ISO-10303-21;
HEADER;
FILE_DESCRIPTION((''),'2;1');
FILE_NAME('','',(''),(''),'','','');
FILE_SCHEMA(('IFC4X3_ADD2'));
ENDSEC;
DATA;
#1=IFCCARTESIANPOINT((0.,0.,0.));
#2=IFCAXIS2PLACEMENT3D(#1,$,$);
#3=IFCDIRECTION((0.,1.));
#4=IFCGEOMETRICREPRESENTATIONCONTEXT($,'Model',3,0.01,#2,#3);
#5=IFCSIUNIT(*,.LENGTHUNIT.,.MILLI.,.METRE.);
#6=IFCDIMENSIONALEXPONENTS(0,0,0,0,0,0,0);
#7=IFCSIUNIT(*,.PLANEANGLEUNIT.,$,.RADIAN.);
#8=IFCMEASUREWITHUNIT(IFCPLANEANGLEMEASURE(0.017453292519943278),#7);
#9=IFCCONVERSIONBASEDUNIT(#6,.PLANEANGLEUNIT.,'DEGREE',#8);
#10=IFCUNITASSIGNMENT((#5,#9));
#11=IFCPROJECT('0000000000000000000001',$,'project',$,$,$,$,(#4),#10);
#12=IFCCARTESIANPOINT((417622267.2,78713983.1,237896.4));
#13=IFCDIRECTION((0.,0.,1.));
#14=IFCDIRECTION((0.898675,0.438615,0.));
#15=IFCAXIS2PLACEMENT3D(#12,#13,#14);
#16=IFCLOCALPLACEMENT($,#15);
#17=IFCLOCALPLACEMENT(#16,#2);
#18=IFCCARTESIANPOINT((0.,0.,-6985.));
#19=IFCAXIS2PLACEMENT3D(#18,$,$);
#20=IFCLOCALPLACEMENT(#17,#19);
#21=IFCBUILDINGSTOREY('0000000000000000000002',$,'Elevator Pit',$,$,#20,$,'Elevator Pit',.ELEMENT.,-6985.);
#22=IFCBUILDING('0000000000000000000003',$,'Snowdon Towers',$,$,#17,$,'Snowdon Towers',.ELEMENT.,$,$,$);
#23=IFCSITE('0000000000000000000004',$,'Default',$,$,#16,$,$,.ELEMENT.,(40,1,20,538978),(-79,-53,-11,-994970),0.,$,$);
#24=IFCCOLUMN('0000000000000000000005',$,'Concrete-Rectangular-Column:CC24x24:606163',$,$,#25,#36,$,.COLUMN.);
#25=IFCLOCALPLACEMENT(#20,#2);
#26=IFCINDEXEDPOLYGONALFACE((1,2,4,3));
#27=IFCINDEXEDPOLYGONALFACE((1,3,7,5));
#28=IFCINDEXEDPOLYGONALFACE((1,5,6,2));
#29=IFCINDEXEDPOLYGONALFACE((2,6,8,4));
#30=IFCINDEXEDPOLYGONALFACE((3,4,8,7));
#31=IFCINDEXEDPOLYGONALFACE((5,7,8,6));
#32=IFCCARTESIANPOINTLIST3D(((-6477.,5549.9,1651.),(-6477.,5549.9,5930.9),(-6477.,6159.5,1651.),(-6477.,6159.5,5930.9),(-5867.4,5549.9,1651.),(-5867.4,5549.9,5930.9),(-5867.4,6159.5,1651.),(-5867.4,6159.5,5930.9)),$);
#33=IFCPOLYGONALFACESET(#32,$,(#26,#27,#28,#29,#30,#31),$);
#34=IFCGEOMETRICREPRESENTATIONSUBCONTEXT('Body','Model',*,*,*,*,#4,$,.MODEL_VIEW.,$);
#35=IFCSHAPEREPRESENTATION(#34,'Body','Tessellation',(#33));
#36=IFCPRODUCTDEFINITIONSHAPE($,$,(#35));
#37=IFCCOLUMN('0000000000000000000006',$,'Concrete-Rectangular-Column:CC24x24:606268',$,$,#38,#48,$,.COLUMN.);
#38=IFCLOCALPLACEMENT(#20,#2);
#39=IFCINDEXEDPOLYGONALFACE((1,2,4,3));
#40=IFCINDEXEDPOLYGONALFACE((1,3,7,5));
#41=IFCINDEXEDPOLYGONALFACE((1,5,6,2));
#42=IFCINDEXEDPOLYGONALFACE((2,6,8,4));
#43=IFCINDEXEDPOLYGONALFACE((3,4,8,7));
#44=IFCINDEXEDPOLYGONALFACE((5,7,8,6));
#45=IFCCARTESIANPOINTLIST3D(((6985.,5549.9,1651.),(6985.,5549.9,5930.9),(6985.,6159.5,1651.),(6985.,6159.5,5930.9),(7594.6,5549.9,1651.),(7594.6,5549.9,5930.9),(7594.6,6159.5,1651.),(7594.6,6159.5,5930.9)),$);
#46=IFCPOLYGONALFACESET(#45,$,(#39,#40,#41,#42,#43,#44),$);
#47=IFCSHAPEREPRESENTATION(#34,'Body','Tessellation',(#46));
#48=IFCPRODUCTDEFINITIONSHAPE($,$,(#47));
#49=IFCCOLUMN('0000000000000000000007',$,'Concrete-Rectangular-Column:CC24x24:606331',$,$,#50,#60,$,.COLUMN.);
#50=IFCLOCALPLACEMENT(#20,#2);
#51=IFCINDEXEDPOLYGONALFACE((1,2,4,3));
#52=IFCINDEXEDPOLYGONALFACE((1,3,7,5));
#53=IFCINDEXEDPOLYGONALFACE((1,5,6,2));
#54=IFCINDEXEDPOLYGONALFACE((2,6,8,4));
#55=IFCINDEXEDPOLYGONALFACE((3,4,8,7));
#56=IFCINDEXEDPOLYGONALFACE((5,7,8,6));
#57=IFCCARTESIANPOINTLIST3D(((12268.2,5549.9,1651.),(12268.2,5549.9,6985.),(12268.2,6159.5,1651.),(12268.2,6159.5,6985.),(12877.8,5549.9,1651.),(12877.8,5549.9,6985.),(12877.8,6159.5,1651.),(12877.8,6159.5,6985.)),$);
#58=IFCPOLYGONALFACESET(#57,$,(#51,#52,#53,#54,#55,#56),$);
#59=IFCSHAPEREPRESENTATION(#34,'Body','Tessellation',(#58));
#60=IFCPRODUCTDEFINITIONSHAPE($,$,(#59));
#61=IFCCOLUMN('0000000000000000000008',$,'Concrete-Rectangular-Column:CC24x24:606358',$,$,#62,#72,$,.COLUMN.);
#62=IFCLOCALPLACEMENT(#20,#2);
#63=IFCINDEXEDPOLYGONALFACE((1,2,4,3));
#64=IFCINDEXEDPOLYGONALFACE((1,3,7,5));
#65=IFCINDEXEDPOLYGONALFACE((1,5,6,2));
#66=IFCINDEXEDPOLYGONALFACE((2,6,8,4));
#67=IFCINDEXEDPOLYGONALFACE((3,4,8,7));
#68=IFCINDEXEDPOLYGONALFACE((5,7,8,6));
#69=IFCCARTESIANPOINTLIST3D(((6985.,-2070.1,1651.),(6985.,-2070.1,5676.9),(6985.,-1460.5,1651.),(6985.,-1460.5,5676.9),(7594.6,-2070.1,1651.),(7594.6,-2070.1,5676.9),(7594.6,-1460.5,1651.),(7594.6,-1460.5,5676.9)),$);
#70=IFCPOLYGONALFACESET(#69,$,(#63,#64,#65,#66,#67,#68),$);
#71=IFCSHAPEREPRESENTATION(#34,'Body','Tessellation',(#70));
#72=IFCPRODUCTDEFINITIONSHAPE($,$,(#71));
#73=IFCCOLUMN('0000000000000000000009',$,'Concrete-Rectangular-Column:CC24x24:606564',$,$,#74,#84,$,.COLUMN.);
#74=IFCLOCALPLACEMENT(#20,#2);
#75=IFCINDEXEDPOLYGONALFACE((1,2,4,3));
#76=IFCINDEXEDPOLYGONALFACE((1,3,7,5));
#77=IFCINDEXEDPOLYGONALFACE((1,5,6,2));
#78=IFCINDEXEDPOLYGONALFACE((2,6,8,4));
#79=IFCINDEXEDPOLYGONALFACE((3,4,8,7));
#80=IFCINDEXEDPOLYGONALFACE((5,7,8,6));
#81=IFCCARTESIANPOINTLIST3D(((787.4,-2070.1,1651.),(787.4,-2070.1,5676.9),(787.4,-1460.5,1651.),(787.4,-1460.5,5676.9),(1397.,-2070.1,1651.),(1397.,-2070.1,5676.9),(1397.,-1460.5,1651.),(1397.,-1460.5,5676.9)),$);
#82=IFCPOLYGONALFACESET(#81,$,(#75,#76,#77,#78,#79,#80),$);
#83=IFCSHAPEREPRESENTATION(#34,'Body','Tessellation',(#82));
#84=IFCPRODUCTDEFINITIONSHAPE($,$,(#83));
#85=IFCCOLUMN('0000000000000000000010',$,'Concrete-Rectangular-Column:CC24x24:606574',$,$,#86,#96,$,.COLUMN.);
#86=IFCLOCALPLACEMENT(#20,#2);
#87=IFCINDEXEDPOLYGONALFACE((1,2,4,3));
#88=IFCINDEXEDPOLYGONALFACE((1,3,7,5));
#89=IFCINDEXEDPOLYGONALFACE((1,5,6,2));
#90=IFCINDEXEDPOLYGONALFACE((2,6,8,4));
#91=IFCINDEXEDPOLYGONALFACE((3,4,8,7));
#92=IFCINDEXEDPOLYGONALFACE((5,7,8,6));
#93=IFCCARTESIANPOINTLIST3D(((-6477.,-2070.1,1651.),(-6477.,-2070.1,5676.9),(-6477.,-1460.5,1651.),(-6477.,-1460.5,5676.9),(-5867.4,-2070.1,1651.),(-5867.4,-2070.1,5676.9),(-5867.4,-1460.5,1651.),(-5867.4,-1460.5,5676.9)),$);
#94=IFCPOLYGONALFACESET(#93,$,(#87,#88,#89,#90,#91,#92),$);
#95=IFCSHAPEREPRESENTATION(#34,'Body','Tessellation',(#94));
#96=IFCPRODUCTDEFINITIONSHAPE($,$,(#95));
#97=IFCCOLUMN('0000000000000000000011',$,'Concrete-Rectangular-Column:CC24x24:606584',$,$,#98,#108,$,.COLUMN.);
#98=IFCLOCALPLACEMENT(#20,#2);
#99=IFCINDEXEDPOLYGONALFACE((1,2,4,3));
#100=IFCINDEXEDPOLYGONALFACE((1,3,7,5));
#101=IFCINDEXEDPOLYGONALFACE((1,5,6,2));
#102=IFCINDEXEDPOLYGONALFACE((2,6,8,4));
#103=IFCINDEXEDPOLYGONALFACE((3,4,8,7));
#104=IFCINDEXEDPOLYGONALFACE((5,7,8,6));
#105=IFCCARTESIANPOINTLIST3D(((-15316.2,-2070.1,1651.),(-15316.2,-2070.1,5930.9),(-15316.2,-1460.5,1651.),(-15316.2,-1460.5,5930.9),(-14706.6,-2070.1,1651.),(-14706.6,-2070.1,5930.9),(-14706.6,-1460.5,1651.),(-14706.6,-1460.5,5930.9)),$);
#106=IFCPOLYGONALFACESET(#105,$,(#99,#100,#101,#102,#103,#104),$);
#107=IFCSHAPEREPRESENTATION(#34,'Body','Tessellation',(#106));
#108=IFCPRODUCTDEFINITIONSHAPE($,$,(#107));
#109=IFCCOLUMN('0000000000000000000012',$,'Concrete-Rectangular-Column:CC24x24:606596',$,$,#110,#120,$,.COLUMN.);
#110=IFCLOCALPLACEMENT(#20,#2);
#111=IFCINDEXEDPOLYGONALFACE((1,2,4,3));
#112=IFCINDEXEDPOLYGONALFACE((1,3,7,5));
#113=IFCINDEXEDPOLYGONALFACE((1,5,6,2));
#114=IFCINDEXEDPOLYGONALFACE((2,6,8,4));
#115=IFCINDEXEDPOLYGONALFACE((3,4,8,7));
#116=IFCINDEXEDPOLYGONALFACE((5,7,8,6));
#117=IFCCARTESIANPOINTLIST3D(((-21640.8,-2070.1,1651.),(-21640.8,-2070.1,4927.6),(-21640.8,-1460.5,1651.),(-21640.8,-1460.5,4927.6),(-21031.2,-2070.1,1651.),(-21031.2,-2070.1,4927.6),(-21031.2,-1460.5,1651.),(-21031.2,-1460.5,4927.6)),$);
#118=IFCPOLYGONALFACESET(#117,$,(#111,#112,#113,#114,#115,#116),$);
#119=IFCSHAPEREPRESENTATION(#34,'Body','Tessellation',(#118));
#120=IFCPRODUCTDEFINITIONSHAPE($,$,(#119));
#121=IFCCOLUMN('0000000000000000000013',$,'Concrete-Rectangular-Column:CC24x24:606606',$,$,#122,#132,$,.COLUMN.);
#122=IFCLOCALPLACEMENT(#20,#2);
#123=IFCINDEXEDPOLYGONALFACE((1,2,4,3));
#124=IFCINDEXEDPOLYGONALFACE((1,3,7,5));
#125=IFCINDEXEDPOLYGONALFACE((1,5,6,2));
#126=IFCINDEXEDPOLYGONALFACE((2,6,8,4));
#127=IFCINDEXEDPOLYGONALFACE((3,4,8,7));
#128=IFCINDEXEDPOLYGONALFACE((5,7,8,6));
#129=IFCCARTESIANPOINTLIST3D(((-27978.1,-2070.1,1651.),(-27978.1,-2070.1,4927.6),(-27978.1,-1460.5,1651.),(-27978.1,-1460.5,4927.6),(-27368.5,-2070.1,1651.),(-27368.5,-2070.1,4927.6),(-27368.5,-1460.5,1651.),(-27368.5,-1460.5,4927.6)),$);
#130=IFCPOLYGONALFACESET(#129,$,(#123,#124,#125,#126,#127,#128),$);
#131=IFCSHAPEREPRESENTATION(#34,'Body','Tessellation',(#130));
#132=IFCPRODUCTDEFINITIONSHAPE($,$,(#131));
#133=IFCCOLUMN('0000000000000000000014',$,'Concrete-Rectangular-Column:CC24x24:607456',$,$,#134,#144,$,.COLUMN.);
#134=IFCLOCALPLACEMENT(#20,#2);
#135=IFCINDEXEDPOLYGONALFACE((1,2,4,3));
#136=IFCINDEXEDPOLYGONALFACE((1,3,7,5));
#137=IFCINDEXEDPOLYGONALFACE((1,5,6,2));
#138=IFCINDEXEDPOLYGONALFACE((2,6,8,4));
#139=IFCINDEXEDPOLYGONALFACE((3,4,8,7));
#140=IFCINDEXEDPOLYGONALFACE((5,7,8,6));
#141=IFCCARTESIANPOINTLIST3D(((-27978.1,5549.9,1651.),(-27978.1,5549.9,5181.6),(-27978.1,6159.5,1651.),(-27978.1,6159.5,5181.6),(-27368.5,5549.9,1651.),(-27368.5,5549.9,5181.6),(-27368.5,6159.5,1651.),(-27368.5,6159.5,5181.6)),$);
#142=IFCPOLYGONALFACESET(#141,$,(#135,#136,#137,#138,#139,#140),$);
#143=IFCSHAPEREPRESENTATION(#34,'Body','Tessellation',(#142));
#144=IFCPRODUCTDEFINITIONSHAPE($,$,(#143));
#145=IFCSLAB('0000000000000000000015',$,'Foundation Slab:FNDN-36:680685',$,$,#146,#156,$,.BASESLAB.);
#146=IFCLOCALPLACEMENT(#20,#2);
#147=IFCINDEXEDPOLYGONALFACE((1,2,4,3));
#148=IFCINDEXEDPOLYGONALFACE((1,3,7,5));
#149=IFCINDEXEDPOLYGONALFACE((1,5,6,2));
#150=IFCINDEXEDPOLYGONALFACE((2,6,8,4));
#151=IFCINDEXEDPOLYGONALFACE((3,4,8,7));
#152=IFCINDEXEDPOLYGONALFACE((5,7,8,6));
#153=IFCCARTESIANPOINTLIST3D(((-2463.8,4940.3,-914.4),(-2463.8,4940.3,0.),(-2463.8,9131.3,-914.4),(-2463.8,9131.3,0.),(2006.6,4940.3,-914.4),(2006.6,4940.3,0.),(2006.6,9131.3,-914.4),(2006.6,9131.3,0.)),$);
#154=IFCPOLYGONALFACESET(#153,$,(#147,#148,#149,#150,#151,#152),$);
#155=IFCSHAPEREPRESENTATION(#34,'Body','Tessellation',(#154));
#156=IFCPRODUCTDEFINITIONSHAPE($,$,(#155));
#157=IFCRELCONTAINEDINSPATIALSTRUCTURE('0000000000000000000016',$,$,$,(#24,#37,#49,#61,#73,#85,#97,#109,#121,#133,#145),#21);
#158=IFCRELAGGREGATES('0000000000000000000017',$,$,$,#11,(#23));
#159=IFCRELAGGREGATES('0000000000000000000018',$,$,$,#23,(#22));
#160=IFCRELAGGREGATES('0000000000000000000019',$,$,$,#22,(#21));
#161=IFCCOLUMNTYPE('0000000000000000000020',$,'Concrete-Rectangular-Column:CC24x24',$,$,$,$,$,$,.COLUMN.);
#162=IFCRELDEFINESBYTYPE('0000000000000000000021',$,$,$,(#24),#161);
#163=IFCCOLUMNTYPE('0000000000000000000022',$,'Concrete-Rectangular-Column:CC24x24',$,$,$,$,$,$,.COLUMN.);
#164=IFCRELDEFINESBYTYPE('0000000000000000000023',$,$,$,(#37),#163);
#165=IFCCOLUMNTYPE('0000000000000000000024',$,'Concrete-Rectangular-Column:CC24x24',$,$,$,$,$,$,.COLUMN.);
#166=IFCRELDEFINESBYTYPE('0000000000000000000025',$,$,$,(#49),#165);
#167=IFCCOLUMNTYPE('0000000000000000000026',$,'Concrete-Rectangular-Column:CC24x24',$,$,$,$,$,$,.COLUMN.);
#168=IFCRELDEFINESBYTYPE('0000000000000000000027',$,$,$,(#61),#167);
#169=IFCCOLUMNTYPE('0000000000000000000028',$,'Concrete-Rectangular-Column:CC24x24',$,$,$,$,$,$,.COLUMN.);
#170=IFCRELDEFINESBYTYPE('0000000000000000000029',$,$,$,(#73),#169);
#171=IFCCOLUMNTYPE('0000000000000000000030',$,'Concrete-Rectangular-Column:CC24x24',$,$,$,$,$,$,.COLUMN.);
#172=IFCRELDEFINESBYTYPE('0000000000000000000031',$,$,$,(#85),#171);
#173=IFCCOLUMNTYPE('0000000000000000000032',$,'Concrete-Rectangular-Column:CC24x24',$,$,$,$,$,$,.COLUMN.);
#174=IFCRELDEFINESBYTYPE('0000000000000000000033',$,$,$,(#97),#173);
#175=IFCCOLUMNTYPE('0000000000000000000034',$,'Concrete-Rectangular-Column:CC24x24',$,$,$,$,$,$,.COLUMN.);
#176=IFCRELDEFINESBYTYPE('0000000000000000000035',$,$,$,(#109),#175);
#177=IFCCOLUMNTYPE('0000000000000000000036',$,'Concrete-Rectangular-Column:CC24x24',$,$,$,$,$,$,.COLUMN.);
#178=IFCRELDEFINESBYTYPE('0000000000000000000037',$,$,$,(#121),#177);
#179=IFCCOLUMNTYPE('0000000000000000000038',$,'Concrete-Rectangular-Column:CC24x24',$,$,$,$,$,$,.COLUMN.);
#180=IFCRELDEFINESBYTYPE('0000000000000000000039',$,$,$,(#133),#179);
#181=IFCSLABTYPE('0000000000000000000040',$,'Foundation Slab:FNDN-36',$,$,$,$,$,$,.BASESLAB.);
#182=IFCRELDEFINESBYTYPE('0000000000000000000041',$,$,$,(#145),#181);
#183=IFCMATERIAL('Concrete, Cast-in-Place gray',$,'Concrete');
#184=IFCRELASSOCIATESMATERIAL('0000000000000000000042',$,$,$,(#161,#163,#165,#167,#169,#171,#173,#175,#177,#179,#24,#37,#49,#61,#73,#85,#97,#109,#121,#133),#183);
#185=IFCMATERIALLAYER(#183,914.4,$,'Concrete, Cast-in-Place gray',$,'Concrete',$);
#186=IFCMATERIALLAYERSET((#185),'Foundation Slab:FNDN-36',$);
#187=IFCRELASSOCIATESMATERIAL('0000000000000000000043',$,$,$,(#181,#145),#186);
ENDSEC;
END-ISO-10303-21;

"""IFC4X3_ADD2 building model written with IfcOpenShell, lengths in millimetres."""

from ifc_helpers import new_model, entity, si_unit, converted_unit, direction, frame, frame_2d, origin, origin_2d_with_axis, place, context, subcontext, project, spatial, rectangle, extrude, source, transform, mapped, material, layer, layer_set, layer_usage, material_profile, profile_set, profile_usage, type_object, type_shapes, element, save


model = new_model("IFC4X3_ADD2")

# Units and contexts
model_context = context("Model", 3, precision=0.01, world=origin(), true_north=direction((0.0, 1.0)))
body_context = subcontext(model_context, "Body", "Model", "MODEL_VIEW")
ifc_project = project(units=[si_unit("LENGTHUNIT", "METRE", prefix="MILLI"), converted_unit("PLANEANGLEUNIT", "DEGREE", entity("IfcPlaneAngleMeasure", 0.017453292519943278), si_unit("PLANEANGLEUNIT", "RADIAN"), dimensions=[0, 0, 0, 0, 0, 0, 0])], contexts=[model_context])

# Site, building, storey
site_placement = place(None, frame((417622267.2, 78713983.1, 237896.4), z_axis=(0.0, 0.0, 1.0), x_axis=(0.898675, 0.438615, 0.0)))
site = spatial("IfcSite", under=ifc_project, at=site_placement, Name="Default", CompositionType="ELEMENT", RefLatitude=(40, 1, 20, 538978), RefLongitude=(-79, -53, -11, -994970), RefElevation=0.0)
building_placement = place(site_placement, origin())
building = spatial("IfcBuilding", under=site, at=building_placement, Name="Snowdon Towers", LongName="Snowdon Towers", CompositionType="ELEMENT")
storey_placement = place(building_placement, frame((0.0, 0.0, -6985.0)))
storey = spatial("IfcBuildingStorey", under=building, at=storey_placement, Name="Elevator Pit", LongName="Elevator Pit", CompositionType="ELEMENT", Elevation=-6985.0)

# Columns
ifc_material = material(Name="Concrete, Cast-in-Place gray", Category="Concrete")
ifc_material_profile = material_profile(ifc_material, rectangle(XDim=609.6, YDim=609.6, at=origin_2d_with_axis()), Name="CC24x24")
ifc_profile_set = profile_set([ifc_material_profile], Name="CC24x24")
ifc_profile_usage = profile_usage(ifc_profile_set)
column_type_1 = type_object("IfcColumnType", Name="Concrete-Rectangular-Column:CC24x24", PredefinedType="COLUMN", material=ifc_profile_set)
shared_shape_1 = source(origin(), body_context, "Body", "SweptSolid", [
    extrude(rectangle(XDim=609.6, YDim=609.6, at=origin_2d_with_axis()), frame((-6172.2, 5854.7, -5334.0), z_axis=(0.0, 0.0, 1.0), x_axis=(-1.0, 0.0, 0.0)), (0.0, 0.0, 1.0), 4279.9),
])
type_shapes(column_type_1, [shared_shape_1])
column_1_placement = place(storey_placement, frame((0.0, 0.0, 6985.0)))
element("IfcColumn", 1, at=column_1_placement, inside=storey, type_object=column_type_1, material=ifc_profile_usage, Name="Concrete-Rectangular-Column:CC24x24:606163", PredefinedType="COLUMN", context=body_context, shape_type="MappedRepresentation", body=[
    mapped(shared_shape_1, transform((0.0, 0.0, 0.0), scale=1.0)),
])
column_type_2 = type_object("IfcColumnType", Name="Concrete-Rectangular-Column:CC24x24", PredefinedType="COLUMN", material=ifc_profile_set)
shared_shape_2 = source(origin(), body_context, "Body", "SweptSolid", [
    extrude(rectangle(XDim=609.6, YDim=609.6, at=origin_2d_with_axis()), frame((7289.8, 5854.7, -5334.0), z_axis=(0.0, 0.0, 1.0), x_axis=(-1.0, 0.0, 0.0)), (0.0, 0.0, 1.0), 4279.9),
])
type_shapes(column_type_2, [shared_shape_2])
column_2_placement = place(storey_placement, frame((0.0, 0.0, 6985.0)))
element("IfcColumn", 2, at=column_2_placement, inside=storey, type_object=column_type_2, material=ifc_profile_usage, Name="Concrete-Rectangular-Column:CC24x24:606268", PredefinedType="COLUMN", context=body_context, shape_type="MappedRepresentation", body=[
    mapped(shared_shape_2, transform((0.0, 0.0, 0.0), scale=1.0)),
])
column_type_3 = type_object("IfcColumnType", Name="Concrete-Rectangular-Column:CC24x24", PredefinedType="COLUMN", material=ifc_profile_set)
shared_shape_3 = source(origin(), body_context, "Body", "SweptSolid", [
    extrude(rectangle(XDim=609.6, YDim=609.6, at=origin_2d_with_axis()), frame((12573.0, 5854.7, -5334.0), z_axis=(0.0, 0.0, 1.0), x_axis=(-1.0, 0.0, 0.0)), (0.0, 0.0, 1.0), 5334.0),
])
type_shapes(column_type_3, [shared_shape_3])
column_3_placement = place(storey_placement, frame((0.0, 0.0, 6985.0)))
element("IfcColumn", 3, at=column_3_placement, inside=storey, type_object=column_type_3, material=ifc_profile_usage, Name="Concrete-Rectangular-Column:CC24x24:606331", PredefinedType="COLUMN", context=body_context, shape_type="MappedRepresentation", body=[
    mapped(shared_shape_3, transform((0.0, 0.0, 0.0), scale=1.0)),
])
column_type_4 = type_object("IfcColumnType", Name="Concrete-Rectangular-Column:CC24x24", PredefinedType="COLUMN", material=ifc_profile_set)
shared_shape_4 = source(origin(), body_context, "Body", "SweptSolid", [
    extrude(rectangle(XDim=609.6, YDim=609.6, at=origin_2d_with_axis()), frame((7289.8, -1765.3, -5334.0), z_axis=(0.0, 0.0, 1.0), x_axis=(-1.0, 0.0, 0.0)), (0.0, 0.0, 1.0), 4025.9),
])
type_shapes(column_type_4, [shared_shape_4])
column_4_placement = place(storey_placement, frame((0.0, 0.0, 6985.0)))
element("IfcColumn", 4, at=column_4_placement, inside=storey, type_object=column_type_4, material=ifc_profile_usage, Name="Concrete-Rectangular-Column:CC24x24:606358", PredefinedType="COLUMN", context=body_context, shape_type="MappedRepresentation", body=[
    mapped(shared_shape_4, transform((0.0, 0.0, 0.0), scale=1.0)),
])
column_type_5 = type_object("IfcColumnType", Name="Concrete-Rectangular-Column:CC24x24", PredefinedType="COLUMN", material=ifc_profile_set)
shared_shape_5 = source(origin(), body_context, "Body", "SweptSolid", [
    extrude(rectangle(XDim=609.6, YDim=609.6, at=origin_2d_with_axis()), frame((1092.2, -1765.3, -5334.0), z_axis=(0.0, 0.0, 1.0), x_axis=(-1.0, 0.0, 0.0)), (0.0, 0.0, 1.0), 4025.9),
])
type_shapes(column_type_5, [shared_shape_5])
column_5_placement = place(storey_placement, frame((0.0, 0.0, 6985.0)))
element("IfcColumn", 5, at=column_5_placement, inside=storey, type_object=column_type_5, material=ifc_profile_usage, Name="Concrete-Rectangular-Column:CC24x24:606564", PredefinedType="COLUMN", context=body_context, shape_type="MappedRepresentation", body=[
    mapped(shared_shape_5, transform((0.0, 0.0, 0.0), scale=1.0)),
])
column_type_6 = type_object("IfcColumnType", Name="Concrete-Rectangular-Column:CC24x24", PredefinedType="COLUMN", material=ifc_profile_set)
shared_shape_6 = source(origin(), body_context, "Body", "SweptSolid", [
    extrude(rectangle(XDim=609.6, YDim=609.6, at=origin_2d_with_axis()), frame((-6172.2, -1765.3, -5334.0), z_axis=(0.0, 0.0, 1.0), x_axis=(-1.0, 0.0, 0.0)), (0.0, 0.0, 1.0), 4025.9),
])
type_shapes(column_type_6, [shared_shape_6])
column_6_placement = place(storey_placement, frame((0.0, 0.0, 6985.0)))
element("IfcColumn", 6, at=column_6_placement, inside=storey, type_object=column_type_6, material=ifc_profile_usage, Name="Concrete-Rectangular-Column:CC24x24:606574", PredefinedType="COLUMN", context=body_context, shape_type="MappedRepresentation", body=[
    mapped(shared_shape_6, transform((0.0, 0.0, 0.0), scale=1.0)),
])
column_type_7 = type_object("IfcColumnType", Name="Concrete-Rectangular-Column:CC24x24", PredefinedType="COLUMN", material=ifc_profile_set)
shared_shape_7 = source(origin(), body_context, "Body", "SweptSolid", [
    extrude(rectangle(XDim=609.6, YDim=609.6, at=origin_2d_with_axis()), frame((-15011.4, -1765.3, -5334.0), z_axis=(0.0, 0.0, 1.0), x_axis=(-1.0, 0.0, 0.0)), (0.0, 0.0, 1.0), 4279.9),
])
type_shapes(column_type_7, [shared_shape_7])
column_7_placement = place(storey_placement, frame((0.0, 0.0, 6985.0)))
element("IfcColumn", 7, at=column_7_placement, inside=storey, type_object=column_type_7, material=ifc_profile_usage, Name="Concrete-Rectangular-Column:CC24x24:606584", PredefinedType="COLUMN", context=body_context, shape_type="MappedRepresentation", body=[
    mapped(shared_shape_7, transform((0.0, 0.0, 0.0), scale=1.0)),
])
column_type_8 = type_object("IfcColumnType", Name="Concrete-Rectangular-Column:CC24x24", PredefinedType="COLUMN", material=ifc_profile_set)
shared_shape_8 = source(origin(), body_context, "Body", "SweptSolid", [
    extrude(rectangle(XDim=609.6, YDim=609.6, at=origin_2d_with_axis()), frame((-21336.0, -1765.3, -5334.0), z_axis=(0.0, 0.0, 1.0), x_axis=(-1.0, 0.0, 0.0)), (0.0, 0.0, 1.0), 3276.6),
])
type_shapes(column_type_8, [shared_shape_8])
column_8_placement = place(storey_placement, frame((0.0, 0.0, 6985.0)))
element("IfcColumn", 8, at=column_8_placement, inside=storey, type_object=column_type_8, material=ifc_profile_usage, Name="Concrete-Rectangular-Column:CC24x24:606596", PredefinedType="COLUMN", context=body_context, shape_type="MappedRepresentation", body=[
    mapped(shared_shape_8, transform((0.0, 0.0, 0.0), scale=1.0)),
])
column_type_9 = type_object("IfcColumnType", Name="Concrete-Rectangular-Column:CC24x24", PredefinedType="COLUMN", material=ifc_profile_set)
shared_shape_9 = source(origin(), body_context, "Body", "SweptSolid", [
    extrude(rectangle(XDim=609.6, YDim=609.6, at=origin_2d_with_axis()), frame((-27673.3, -1765.3, -5334.0), z_axis=(0.0, 0.0, 1.0), x_axis=(-1.0, 0.0, 0.0)), (0.0, 0.0, 1.0), 3276.6),
])
type_shapes(column_type_9, [shared_shape_9])
column_9_placement = place(storey_placement, frame((0.0, 0.0, 6985.0)))
element("IfcColumn", 9, at=column_9_placement, inside=storey, type_object=column_type_9, material=ifc_profile_usage, Name="Concrete-Rectangular-Column:CC24x24:606606", PredefinedType="COLUMN", context=body_context, shape_type="MappedRepresentation", body=[
    mapped(shared_shape_9, transform((0.0, 0.0, 0.0), scale=1.0)),
])
column_type_10 = type_object("IfcColumnType", Name="Concrete-Rectangular-Column:CC24x24", PredefinedType="COLUMN", material=ifc_profile_set)
shared_shape_10 = source(origin(), body_context, "Body", "SweptSolid", [
    extrude(rectangle(XDim=609.6, YDim=609.6, at=origin_2d_with_axis()), frame((-27673.3, 5854.7, -5334.0), z_axis=(0.0, 0.0, 1.0), x_axis=(-1.0, 0.0, 0.0)), (0.0, 0.0, 1.0), 3530.6),
])
type_shapes(column_type_10, [shared_shape_10])
column_10_placement = place(storey_placement, frame((0.0, 0.0, 6985.0)))
element("IfcColumn", 10, at=column_10_placement, inside=storey, type_object=column_type_10, material=ifc_profile_usage, Name="Concrete-Rectangular-Column:CC24x24:607456", PredefinedType="COLUMN", context=body_context, shape_type="MappedRepresentation", body=[
    mapped(shared_shape_10, transform((0.0, 0.0, 0.0), scale=1.0)),
])

# Slab
ifc_layer = layer(ifc_material, 914.4, Name="Concrete, Cast-in-Place gray", Category="Concrete")
ifc_layer_set = layer_set([ifc_layer], Name="Foundation Slab:FNDN-36")
ifc_layer_usage = layer_usage(ifc_layer_set, "AXIS3", "POSITIVE", 0.0)
slab_type_1 = type_object("IfcSlabType", Name="Foundation Slab:FNDN-36", PredefinedType="BASESLAB", material=ifc_layer_set)
slab_1_placement = place(storey_placement, origin())
element("IfcSlab", 11, at=slab_1_placement, inside=storey, type_object=slab_type_1, material=ifc_layer_usage, Name="Foundation Slab:FNDN-36:680685", PredefinedType="BASESLAB", context=body_context, shape_type="SweptSolid", body=[
    extrude(rectangle(XDim=4191.0, YDim=4470.4, at=frame_2d((0.0, 0.0), x_axis=(1.0, 0.0))), frame((-228.6, 7035.8, 0.0), z_axis=(0.0, 0.0, -1.0), x_axis=(0.0, 1.0, 0.0)), (0.0, 0.0, 1.0), 914.4),
])

save(model, "model.ifc")
